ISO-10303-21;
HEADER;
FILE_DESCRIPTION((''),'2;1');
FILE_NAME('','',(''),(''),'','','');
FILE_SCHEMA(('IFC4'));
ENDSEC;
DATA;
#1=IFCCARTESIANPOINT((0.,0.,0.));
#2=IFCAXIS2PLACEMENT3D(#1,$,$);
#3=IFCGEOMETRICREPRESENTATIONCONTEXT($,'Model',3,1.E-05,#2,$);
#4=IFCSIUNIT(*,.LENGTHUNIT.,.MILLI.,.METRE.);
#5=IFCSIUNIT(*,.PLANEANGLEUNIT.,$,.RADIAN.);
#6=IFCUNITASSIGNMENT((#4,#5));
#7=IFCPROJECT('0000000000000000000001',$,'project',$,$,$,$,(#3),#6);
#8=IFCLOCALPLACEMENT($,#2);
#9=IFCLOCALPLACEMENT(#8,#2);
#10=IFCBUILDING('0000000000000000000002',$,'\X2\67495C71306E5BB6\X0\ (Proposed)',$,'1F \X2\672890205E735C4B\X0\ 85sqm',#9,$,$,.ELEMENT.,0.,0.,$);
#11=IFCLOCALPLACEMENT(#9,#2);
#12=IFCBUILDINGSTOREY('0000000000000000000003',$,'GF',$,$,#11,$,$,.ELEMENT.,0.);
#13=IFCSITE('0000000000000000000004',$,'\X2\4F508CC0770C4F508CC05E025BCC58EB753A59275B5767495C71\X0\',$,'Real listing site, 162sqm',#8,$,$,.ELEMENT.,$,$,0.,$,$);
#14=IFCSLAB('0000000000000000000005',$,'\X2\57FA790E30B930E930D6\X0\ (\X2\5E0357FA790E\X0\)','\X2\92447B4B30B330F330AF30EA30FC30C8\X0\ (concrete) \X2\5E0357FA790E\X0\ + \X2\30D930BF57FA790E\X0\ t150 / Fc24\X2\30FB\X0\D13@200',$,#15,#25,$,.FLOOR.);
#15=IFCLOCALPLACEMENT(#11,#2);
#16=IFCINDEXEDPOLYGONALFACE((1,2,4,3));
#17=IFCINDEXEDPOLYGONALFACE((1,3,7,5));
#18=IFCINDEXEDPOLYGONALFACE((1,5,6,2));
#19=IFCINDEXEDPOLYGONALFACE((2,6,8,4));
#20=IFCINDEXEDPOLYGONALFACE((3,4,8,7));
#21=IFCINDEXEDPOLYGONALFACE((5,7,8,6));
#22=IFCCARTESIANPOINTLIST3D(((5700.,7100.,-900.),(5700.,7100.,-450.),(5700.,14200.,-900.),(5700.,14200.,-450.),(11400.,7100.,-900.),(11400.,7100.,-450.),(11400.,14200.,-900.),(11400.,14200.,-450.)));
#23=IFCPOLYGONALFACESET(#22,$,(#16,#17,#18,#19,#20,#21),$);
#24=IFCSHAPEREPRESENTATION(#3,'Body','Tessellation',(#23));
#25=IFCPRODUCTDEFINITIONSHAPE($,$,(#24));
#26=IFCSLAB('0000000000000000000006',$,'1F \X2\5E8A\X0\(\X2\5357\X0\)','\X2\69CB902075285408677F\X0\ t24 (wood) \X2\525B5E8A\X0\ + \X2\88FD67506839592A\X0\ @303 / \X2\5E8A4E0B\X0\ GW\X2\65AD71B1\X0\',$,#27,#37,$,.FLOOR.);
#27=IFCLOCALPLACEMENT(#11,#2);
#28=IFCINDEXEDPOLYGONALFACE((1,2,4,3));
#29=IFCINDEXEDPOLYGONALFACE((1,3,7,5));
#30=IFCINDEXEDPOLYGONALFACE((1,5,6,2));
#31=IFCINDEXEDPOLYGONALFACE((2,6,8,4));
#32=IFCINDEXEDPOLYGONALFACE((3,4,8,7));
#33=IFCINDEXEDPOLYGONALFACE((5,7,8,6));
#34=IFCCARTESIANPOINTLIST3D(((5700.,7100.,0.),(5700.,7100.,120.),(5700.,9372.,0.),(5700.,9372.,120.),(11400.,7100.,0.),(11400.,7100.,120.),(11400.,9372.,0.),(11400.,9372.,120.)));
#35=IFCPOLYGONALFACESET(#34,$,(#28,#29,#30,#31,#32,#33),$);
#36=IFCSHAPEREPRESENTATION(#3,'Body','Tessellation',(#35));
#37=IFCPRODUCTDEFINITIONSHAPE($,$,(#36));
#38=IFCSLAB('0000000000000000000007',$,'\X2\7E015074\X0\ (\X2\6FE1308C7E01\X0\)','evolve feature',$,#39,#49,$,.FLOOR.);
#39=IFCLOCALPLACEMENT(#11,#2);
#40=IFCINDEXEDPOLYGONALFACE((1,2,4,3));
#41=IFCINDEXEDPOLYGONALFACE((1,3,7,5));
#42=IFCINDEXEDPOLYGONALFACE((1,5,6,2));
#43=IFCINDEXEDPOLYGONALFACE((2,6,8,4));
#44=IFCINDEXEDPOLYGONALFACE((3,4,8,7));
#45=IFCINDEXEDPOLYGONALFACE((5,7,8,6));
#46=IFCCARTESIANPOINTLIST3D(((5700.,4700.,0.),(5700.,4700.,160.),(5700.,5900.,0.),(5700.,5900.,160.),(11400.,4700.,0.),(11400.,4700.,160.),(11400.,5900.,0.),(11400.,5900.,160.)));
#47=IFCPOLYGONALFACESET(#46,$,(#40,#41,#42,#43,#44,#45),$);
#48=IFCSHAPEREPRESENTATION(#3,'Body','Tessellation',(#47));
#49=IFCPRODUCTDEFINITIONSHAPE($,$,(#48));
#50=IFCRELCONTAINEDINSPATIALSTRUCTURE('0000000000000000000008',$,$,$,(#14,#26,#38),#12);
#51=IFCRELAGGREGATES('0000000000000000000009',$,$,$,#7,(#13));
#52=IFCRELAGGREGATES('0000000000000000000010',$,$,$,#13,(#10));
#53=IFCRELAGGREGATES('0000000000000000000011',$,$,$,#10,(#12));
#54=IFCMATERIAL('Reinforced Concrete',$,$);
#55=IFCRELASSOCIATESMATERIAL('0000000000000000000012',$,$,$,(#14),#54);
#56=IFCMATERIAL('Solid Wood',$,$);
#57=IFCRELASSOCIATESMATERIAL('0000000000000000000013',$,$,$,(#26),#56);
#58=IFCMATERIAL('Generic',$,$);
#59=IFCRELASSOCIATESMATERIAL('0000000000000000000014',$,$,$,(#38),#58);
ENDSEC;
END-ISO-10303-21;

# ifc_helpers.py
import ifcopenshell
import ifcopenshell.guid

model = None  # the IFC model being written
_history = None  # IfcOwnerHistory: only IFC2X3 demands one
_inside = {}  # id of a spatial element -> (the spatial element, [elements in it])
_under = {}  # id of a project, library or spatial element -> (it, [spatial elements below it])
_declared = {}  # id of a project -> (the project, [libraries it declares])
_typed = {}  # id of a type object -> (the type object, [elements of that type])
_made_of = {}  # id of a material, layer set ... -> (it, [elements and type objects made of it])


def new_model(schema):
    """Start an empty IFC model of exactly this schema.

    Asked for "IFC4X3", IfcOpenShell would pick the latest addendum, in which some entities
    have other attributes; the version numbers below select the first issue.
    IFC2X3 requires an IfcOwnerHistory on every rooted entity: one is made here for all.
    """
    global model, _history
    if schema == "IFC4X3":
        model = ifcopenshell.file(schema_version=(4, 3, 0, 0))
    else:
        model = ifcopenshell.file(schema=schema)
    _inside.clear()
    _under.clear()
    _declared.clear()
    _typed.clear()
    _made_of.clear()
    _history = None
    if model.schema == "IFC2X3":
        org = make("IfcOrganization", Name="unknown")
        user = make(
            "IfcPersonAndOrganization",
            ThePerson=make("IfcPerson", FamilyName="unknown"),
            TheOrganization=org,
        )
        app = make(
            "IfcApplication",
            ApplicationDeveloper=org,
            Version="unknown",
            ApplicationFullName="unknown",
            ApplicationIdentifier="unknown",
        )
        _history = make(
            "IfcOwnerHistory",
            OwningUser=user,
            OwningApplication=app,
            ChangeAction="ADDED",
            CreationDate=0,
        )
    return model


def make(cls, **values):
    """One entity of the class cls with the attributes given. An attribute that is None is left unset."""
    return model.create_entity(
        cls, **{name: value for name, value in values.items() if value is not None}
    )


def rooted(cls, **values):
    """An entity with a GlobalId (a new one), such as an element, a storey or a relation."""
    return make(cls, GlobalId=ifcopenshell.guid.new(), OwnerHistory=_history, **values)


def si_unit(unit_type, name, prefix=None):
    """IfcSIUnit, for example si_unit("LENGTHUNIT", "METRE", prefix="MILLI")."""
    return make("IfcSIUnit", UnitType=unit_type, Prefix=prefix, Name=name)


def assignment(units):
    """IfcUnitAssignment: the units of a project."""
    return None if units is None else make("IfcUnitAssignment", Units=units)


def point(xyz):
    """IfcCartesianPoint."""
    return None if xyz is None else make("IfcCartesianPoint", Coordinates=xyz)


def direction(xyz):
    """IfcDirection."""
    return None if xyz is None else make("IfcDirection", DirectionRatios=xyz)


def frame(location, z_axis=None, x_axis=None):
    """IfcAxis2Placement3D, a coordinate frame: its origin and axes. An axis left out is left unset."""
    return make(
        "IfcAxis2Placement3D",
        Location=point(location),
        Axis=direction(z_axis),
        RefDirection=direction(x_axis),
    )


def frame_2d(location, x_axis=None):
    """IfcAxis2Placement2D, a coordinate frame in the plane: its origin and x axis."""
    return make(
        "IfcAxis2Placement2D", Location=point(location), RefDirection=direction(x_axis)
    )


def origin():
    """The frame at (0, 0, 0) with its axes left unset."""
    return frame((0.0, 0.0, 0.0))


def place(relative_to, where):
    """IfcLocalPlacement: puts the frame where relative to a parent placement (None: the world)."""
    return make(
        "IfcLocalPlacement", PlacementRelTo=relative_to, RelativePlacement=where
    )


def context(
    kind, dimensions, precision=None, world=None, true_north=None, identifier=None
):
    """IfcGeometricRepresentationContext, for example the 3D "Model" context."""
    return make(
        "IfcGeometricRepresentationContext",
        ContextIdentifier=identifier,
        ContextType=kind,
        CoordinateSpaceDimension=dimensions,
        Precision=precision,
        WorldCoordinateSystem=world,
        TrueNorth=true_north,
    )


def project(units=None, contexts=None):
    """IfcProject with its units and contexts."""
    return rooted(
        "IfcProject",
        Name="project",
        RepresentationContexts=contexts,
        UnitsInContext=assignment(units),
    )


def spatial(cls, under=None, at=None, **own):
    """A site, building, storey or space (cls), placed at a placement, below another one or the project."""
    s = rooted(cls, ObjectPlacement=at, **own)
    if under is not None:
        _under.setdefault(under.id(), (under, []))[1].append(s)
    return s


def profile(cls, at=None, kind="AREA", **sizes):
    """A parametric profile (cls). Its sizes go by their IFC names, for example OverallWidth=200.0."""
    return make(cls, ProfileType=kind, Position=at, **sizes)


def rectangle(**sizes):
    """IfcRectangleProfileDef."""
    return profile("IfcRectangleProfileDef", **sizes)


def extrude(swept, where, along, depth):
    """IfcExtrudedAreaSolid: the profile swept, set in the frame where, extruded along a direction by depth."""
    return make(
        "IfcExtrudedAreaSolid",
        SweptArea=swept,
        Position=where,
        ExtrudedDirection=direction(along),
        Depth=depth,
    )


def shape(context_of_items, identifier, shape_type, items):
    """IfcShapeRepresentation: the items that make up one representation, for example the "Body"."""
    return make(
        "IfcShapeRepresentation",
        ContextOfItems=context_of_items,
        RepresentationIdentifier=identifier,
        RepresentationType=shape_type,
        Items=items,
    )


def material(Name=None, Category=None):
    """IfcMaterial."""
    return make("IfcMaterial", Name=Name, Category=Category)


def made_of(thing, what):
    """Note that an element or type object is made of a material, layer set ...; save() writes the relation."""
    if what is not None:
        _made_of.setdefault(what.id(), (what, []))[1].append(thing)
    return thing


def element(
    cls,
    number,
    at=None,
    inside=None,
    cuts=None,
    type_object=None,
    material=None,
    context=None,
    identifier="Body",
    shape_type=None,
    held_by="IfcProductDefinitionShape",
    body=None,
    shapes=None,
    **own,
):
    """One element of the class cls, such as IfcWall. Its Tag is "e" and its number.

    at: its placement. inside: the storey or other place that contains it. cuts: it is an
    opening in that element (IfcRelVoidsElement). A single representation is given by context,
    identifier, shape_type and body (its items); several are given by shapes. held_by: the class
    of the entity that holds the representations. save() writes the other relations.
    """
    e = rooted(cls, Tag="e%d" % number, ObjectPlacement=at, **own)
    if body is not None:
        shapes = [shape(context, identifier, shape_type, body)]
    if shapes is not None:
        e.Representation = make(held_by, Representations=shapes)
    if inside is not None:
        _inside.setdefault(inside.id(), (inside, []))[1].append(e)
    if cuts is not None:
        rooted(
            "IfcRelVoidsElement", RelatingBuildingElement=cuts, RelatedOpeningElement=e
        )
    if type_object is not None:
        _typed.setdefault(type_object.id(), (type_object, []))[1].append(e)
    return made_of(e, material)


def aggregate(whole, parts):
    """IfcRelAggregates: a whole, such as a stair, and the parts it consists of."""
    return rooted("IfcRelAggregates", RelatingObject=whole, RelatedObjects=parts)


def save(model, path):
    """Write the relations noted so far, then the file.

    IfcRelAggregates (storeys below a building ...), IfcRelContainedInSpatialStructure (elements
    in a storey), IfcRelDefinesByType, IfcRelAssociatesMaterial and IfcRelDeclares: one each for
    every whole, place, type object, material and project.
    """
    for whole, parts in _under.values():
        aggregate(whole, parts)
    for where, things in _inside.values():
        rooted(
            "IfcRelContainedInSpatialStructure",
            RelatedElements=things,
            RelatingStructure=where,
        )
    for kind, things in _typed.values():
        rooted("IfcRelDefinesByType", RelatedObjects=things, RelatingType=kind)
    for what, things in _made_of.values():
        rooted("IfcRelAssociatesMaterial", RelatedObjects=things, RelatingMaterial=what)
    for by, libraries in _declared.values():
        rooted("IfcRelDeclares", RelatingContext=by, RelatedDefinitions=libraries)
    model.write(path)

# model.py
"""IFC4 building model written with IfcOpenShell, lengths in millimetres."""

from ifc_helpers import new_model, si_unit, frame, frame_2d, origin, place, context, project, spatial, rectangle, extrude, material, element, save


model = new_model("IFC4")

# Units and contexts
model_context = context("Model", 3, precision=1e-05, world=origin())
ifc_project = project(units=[si_unit("LENGTHUNIT", "METRE", prefix="MILLI"), si_unit("PLANEANGLEUNIT", "RADIAN")], contexts=[model_context])

# Site, building, storey
site_placement = place(None, origin())
site = spatial("IfcSite", under=ifc_project, at=site_placement, Name="佐賀県佐賀市富士町大字杉山", ObjectType="Real listing site, 162sqm", CompositionType="ELEMENT", RefElevation=0.0)
building_placement = place(site_placement, origin())
building = spatial("IfcBuilding", under=site, at=building_placement, Name="杉山の家 (Proposed)", ObjectType="1F 木造平屋 85sqm", CompositionType="ELEMENT", ElevationOfRefHeight=0.0, ElevationOfTerrain=0.0)
storey_placement = place(building_placement, origin())
storey = spatial("IfcBuildingStorey", under=building, at=storey_placement, Name="GF", CompositionType="ELEMENT", Elevation=0.0)

# Slabs
ifc_material_1 = material(Name="Reinforced Concrete")
slab_1_placement = place(storey_placement, frame((2850.0, 3550.0, -450.0)))
element("IfcSlab", 1, at=slab_1_placement, inside=storey, material=ifc_material_1, Name="基礎スラブ (布基礎)", Description="鉄筋コンクリート (concrete) 布基礎 + ベタ基礎 t150 / Fc24・D13@200", PredefinedType="FLOOR", context=model_context, shape_type="SweptSolid", body=[
    extrude(rectangle(XDim=5700.0, YDim=7100.0, at=frame_2d((2850.0, 3550.0))), frame((2850.0, 3550.0, -450.0)), (0.0, 0.0, 1.0), 450.0),
])
ifc_material_2 = material(Name="Solid Wood")
slab_2_placement = place(storey_placement, frame((2850.0, 3550.0, 0.0)))
element("IfcSlab", 2, at=slab_2_placement, inside=storey, material=ifc_material_2, Name="1F 床(南)", Description="構造用合板 t24 (wood) 剛床 + 製材根太 @303 / 床下 GW断熱", PredefinedType="FLOOR", context=model_context, shape_type="SweptSolid", body=[
    extrude(rectangle(XDim=5700.0, YDim=2272.0, at=frame_2d((2850.0, 1136.0))), frame((2850.0, 3550.0, 0.0)), (0.0, 0.0, 1.0), 120.0),
])
ifc_material_3 = material(Name="Generic")
slab_3_placement = place(storey_placement, frame((2850.0, 2350.0, 0.0)))
element("IfcSlab", 3, at=slab_3_placement, inside=storey, material=ifc_material_3, Name="縁側 (濡れ縁)", Description="evolve feature", PredefinedType="FLOOR", context=model_context, shape_type="SweptSolid", body=[
    extrude(rectangle(XDim=5700.0, YDim=1200.0, at=frame_2d((2850.0, 600.0))), frame((2850.0, 2350.0, 0.0)), (0.0, 0.0, 1.0), 160.0),
])

save(model, "model.ifc")
